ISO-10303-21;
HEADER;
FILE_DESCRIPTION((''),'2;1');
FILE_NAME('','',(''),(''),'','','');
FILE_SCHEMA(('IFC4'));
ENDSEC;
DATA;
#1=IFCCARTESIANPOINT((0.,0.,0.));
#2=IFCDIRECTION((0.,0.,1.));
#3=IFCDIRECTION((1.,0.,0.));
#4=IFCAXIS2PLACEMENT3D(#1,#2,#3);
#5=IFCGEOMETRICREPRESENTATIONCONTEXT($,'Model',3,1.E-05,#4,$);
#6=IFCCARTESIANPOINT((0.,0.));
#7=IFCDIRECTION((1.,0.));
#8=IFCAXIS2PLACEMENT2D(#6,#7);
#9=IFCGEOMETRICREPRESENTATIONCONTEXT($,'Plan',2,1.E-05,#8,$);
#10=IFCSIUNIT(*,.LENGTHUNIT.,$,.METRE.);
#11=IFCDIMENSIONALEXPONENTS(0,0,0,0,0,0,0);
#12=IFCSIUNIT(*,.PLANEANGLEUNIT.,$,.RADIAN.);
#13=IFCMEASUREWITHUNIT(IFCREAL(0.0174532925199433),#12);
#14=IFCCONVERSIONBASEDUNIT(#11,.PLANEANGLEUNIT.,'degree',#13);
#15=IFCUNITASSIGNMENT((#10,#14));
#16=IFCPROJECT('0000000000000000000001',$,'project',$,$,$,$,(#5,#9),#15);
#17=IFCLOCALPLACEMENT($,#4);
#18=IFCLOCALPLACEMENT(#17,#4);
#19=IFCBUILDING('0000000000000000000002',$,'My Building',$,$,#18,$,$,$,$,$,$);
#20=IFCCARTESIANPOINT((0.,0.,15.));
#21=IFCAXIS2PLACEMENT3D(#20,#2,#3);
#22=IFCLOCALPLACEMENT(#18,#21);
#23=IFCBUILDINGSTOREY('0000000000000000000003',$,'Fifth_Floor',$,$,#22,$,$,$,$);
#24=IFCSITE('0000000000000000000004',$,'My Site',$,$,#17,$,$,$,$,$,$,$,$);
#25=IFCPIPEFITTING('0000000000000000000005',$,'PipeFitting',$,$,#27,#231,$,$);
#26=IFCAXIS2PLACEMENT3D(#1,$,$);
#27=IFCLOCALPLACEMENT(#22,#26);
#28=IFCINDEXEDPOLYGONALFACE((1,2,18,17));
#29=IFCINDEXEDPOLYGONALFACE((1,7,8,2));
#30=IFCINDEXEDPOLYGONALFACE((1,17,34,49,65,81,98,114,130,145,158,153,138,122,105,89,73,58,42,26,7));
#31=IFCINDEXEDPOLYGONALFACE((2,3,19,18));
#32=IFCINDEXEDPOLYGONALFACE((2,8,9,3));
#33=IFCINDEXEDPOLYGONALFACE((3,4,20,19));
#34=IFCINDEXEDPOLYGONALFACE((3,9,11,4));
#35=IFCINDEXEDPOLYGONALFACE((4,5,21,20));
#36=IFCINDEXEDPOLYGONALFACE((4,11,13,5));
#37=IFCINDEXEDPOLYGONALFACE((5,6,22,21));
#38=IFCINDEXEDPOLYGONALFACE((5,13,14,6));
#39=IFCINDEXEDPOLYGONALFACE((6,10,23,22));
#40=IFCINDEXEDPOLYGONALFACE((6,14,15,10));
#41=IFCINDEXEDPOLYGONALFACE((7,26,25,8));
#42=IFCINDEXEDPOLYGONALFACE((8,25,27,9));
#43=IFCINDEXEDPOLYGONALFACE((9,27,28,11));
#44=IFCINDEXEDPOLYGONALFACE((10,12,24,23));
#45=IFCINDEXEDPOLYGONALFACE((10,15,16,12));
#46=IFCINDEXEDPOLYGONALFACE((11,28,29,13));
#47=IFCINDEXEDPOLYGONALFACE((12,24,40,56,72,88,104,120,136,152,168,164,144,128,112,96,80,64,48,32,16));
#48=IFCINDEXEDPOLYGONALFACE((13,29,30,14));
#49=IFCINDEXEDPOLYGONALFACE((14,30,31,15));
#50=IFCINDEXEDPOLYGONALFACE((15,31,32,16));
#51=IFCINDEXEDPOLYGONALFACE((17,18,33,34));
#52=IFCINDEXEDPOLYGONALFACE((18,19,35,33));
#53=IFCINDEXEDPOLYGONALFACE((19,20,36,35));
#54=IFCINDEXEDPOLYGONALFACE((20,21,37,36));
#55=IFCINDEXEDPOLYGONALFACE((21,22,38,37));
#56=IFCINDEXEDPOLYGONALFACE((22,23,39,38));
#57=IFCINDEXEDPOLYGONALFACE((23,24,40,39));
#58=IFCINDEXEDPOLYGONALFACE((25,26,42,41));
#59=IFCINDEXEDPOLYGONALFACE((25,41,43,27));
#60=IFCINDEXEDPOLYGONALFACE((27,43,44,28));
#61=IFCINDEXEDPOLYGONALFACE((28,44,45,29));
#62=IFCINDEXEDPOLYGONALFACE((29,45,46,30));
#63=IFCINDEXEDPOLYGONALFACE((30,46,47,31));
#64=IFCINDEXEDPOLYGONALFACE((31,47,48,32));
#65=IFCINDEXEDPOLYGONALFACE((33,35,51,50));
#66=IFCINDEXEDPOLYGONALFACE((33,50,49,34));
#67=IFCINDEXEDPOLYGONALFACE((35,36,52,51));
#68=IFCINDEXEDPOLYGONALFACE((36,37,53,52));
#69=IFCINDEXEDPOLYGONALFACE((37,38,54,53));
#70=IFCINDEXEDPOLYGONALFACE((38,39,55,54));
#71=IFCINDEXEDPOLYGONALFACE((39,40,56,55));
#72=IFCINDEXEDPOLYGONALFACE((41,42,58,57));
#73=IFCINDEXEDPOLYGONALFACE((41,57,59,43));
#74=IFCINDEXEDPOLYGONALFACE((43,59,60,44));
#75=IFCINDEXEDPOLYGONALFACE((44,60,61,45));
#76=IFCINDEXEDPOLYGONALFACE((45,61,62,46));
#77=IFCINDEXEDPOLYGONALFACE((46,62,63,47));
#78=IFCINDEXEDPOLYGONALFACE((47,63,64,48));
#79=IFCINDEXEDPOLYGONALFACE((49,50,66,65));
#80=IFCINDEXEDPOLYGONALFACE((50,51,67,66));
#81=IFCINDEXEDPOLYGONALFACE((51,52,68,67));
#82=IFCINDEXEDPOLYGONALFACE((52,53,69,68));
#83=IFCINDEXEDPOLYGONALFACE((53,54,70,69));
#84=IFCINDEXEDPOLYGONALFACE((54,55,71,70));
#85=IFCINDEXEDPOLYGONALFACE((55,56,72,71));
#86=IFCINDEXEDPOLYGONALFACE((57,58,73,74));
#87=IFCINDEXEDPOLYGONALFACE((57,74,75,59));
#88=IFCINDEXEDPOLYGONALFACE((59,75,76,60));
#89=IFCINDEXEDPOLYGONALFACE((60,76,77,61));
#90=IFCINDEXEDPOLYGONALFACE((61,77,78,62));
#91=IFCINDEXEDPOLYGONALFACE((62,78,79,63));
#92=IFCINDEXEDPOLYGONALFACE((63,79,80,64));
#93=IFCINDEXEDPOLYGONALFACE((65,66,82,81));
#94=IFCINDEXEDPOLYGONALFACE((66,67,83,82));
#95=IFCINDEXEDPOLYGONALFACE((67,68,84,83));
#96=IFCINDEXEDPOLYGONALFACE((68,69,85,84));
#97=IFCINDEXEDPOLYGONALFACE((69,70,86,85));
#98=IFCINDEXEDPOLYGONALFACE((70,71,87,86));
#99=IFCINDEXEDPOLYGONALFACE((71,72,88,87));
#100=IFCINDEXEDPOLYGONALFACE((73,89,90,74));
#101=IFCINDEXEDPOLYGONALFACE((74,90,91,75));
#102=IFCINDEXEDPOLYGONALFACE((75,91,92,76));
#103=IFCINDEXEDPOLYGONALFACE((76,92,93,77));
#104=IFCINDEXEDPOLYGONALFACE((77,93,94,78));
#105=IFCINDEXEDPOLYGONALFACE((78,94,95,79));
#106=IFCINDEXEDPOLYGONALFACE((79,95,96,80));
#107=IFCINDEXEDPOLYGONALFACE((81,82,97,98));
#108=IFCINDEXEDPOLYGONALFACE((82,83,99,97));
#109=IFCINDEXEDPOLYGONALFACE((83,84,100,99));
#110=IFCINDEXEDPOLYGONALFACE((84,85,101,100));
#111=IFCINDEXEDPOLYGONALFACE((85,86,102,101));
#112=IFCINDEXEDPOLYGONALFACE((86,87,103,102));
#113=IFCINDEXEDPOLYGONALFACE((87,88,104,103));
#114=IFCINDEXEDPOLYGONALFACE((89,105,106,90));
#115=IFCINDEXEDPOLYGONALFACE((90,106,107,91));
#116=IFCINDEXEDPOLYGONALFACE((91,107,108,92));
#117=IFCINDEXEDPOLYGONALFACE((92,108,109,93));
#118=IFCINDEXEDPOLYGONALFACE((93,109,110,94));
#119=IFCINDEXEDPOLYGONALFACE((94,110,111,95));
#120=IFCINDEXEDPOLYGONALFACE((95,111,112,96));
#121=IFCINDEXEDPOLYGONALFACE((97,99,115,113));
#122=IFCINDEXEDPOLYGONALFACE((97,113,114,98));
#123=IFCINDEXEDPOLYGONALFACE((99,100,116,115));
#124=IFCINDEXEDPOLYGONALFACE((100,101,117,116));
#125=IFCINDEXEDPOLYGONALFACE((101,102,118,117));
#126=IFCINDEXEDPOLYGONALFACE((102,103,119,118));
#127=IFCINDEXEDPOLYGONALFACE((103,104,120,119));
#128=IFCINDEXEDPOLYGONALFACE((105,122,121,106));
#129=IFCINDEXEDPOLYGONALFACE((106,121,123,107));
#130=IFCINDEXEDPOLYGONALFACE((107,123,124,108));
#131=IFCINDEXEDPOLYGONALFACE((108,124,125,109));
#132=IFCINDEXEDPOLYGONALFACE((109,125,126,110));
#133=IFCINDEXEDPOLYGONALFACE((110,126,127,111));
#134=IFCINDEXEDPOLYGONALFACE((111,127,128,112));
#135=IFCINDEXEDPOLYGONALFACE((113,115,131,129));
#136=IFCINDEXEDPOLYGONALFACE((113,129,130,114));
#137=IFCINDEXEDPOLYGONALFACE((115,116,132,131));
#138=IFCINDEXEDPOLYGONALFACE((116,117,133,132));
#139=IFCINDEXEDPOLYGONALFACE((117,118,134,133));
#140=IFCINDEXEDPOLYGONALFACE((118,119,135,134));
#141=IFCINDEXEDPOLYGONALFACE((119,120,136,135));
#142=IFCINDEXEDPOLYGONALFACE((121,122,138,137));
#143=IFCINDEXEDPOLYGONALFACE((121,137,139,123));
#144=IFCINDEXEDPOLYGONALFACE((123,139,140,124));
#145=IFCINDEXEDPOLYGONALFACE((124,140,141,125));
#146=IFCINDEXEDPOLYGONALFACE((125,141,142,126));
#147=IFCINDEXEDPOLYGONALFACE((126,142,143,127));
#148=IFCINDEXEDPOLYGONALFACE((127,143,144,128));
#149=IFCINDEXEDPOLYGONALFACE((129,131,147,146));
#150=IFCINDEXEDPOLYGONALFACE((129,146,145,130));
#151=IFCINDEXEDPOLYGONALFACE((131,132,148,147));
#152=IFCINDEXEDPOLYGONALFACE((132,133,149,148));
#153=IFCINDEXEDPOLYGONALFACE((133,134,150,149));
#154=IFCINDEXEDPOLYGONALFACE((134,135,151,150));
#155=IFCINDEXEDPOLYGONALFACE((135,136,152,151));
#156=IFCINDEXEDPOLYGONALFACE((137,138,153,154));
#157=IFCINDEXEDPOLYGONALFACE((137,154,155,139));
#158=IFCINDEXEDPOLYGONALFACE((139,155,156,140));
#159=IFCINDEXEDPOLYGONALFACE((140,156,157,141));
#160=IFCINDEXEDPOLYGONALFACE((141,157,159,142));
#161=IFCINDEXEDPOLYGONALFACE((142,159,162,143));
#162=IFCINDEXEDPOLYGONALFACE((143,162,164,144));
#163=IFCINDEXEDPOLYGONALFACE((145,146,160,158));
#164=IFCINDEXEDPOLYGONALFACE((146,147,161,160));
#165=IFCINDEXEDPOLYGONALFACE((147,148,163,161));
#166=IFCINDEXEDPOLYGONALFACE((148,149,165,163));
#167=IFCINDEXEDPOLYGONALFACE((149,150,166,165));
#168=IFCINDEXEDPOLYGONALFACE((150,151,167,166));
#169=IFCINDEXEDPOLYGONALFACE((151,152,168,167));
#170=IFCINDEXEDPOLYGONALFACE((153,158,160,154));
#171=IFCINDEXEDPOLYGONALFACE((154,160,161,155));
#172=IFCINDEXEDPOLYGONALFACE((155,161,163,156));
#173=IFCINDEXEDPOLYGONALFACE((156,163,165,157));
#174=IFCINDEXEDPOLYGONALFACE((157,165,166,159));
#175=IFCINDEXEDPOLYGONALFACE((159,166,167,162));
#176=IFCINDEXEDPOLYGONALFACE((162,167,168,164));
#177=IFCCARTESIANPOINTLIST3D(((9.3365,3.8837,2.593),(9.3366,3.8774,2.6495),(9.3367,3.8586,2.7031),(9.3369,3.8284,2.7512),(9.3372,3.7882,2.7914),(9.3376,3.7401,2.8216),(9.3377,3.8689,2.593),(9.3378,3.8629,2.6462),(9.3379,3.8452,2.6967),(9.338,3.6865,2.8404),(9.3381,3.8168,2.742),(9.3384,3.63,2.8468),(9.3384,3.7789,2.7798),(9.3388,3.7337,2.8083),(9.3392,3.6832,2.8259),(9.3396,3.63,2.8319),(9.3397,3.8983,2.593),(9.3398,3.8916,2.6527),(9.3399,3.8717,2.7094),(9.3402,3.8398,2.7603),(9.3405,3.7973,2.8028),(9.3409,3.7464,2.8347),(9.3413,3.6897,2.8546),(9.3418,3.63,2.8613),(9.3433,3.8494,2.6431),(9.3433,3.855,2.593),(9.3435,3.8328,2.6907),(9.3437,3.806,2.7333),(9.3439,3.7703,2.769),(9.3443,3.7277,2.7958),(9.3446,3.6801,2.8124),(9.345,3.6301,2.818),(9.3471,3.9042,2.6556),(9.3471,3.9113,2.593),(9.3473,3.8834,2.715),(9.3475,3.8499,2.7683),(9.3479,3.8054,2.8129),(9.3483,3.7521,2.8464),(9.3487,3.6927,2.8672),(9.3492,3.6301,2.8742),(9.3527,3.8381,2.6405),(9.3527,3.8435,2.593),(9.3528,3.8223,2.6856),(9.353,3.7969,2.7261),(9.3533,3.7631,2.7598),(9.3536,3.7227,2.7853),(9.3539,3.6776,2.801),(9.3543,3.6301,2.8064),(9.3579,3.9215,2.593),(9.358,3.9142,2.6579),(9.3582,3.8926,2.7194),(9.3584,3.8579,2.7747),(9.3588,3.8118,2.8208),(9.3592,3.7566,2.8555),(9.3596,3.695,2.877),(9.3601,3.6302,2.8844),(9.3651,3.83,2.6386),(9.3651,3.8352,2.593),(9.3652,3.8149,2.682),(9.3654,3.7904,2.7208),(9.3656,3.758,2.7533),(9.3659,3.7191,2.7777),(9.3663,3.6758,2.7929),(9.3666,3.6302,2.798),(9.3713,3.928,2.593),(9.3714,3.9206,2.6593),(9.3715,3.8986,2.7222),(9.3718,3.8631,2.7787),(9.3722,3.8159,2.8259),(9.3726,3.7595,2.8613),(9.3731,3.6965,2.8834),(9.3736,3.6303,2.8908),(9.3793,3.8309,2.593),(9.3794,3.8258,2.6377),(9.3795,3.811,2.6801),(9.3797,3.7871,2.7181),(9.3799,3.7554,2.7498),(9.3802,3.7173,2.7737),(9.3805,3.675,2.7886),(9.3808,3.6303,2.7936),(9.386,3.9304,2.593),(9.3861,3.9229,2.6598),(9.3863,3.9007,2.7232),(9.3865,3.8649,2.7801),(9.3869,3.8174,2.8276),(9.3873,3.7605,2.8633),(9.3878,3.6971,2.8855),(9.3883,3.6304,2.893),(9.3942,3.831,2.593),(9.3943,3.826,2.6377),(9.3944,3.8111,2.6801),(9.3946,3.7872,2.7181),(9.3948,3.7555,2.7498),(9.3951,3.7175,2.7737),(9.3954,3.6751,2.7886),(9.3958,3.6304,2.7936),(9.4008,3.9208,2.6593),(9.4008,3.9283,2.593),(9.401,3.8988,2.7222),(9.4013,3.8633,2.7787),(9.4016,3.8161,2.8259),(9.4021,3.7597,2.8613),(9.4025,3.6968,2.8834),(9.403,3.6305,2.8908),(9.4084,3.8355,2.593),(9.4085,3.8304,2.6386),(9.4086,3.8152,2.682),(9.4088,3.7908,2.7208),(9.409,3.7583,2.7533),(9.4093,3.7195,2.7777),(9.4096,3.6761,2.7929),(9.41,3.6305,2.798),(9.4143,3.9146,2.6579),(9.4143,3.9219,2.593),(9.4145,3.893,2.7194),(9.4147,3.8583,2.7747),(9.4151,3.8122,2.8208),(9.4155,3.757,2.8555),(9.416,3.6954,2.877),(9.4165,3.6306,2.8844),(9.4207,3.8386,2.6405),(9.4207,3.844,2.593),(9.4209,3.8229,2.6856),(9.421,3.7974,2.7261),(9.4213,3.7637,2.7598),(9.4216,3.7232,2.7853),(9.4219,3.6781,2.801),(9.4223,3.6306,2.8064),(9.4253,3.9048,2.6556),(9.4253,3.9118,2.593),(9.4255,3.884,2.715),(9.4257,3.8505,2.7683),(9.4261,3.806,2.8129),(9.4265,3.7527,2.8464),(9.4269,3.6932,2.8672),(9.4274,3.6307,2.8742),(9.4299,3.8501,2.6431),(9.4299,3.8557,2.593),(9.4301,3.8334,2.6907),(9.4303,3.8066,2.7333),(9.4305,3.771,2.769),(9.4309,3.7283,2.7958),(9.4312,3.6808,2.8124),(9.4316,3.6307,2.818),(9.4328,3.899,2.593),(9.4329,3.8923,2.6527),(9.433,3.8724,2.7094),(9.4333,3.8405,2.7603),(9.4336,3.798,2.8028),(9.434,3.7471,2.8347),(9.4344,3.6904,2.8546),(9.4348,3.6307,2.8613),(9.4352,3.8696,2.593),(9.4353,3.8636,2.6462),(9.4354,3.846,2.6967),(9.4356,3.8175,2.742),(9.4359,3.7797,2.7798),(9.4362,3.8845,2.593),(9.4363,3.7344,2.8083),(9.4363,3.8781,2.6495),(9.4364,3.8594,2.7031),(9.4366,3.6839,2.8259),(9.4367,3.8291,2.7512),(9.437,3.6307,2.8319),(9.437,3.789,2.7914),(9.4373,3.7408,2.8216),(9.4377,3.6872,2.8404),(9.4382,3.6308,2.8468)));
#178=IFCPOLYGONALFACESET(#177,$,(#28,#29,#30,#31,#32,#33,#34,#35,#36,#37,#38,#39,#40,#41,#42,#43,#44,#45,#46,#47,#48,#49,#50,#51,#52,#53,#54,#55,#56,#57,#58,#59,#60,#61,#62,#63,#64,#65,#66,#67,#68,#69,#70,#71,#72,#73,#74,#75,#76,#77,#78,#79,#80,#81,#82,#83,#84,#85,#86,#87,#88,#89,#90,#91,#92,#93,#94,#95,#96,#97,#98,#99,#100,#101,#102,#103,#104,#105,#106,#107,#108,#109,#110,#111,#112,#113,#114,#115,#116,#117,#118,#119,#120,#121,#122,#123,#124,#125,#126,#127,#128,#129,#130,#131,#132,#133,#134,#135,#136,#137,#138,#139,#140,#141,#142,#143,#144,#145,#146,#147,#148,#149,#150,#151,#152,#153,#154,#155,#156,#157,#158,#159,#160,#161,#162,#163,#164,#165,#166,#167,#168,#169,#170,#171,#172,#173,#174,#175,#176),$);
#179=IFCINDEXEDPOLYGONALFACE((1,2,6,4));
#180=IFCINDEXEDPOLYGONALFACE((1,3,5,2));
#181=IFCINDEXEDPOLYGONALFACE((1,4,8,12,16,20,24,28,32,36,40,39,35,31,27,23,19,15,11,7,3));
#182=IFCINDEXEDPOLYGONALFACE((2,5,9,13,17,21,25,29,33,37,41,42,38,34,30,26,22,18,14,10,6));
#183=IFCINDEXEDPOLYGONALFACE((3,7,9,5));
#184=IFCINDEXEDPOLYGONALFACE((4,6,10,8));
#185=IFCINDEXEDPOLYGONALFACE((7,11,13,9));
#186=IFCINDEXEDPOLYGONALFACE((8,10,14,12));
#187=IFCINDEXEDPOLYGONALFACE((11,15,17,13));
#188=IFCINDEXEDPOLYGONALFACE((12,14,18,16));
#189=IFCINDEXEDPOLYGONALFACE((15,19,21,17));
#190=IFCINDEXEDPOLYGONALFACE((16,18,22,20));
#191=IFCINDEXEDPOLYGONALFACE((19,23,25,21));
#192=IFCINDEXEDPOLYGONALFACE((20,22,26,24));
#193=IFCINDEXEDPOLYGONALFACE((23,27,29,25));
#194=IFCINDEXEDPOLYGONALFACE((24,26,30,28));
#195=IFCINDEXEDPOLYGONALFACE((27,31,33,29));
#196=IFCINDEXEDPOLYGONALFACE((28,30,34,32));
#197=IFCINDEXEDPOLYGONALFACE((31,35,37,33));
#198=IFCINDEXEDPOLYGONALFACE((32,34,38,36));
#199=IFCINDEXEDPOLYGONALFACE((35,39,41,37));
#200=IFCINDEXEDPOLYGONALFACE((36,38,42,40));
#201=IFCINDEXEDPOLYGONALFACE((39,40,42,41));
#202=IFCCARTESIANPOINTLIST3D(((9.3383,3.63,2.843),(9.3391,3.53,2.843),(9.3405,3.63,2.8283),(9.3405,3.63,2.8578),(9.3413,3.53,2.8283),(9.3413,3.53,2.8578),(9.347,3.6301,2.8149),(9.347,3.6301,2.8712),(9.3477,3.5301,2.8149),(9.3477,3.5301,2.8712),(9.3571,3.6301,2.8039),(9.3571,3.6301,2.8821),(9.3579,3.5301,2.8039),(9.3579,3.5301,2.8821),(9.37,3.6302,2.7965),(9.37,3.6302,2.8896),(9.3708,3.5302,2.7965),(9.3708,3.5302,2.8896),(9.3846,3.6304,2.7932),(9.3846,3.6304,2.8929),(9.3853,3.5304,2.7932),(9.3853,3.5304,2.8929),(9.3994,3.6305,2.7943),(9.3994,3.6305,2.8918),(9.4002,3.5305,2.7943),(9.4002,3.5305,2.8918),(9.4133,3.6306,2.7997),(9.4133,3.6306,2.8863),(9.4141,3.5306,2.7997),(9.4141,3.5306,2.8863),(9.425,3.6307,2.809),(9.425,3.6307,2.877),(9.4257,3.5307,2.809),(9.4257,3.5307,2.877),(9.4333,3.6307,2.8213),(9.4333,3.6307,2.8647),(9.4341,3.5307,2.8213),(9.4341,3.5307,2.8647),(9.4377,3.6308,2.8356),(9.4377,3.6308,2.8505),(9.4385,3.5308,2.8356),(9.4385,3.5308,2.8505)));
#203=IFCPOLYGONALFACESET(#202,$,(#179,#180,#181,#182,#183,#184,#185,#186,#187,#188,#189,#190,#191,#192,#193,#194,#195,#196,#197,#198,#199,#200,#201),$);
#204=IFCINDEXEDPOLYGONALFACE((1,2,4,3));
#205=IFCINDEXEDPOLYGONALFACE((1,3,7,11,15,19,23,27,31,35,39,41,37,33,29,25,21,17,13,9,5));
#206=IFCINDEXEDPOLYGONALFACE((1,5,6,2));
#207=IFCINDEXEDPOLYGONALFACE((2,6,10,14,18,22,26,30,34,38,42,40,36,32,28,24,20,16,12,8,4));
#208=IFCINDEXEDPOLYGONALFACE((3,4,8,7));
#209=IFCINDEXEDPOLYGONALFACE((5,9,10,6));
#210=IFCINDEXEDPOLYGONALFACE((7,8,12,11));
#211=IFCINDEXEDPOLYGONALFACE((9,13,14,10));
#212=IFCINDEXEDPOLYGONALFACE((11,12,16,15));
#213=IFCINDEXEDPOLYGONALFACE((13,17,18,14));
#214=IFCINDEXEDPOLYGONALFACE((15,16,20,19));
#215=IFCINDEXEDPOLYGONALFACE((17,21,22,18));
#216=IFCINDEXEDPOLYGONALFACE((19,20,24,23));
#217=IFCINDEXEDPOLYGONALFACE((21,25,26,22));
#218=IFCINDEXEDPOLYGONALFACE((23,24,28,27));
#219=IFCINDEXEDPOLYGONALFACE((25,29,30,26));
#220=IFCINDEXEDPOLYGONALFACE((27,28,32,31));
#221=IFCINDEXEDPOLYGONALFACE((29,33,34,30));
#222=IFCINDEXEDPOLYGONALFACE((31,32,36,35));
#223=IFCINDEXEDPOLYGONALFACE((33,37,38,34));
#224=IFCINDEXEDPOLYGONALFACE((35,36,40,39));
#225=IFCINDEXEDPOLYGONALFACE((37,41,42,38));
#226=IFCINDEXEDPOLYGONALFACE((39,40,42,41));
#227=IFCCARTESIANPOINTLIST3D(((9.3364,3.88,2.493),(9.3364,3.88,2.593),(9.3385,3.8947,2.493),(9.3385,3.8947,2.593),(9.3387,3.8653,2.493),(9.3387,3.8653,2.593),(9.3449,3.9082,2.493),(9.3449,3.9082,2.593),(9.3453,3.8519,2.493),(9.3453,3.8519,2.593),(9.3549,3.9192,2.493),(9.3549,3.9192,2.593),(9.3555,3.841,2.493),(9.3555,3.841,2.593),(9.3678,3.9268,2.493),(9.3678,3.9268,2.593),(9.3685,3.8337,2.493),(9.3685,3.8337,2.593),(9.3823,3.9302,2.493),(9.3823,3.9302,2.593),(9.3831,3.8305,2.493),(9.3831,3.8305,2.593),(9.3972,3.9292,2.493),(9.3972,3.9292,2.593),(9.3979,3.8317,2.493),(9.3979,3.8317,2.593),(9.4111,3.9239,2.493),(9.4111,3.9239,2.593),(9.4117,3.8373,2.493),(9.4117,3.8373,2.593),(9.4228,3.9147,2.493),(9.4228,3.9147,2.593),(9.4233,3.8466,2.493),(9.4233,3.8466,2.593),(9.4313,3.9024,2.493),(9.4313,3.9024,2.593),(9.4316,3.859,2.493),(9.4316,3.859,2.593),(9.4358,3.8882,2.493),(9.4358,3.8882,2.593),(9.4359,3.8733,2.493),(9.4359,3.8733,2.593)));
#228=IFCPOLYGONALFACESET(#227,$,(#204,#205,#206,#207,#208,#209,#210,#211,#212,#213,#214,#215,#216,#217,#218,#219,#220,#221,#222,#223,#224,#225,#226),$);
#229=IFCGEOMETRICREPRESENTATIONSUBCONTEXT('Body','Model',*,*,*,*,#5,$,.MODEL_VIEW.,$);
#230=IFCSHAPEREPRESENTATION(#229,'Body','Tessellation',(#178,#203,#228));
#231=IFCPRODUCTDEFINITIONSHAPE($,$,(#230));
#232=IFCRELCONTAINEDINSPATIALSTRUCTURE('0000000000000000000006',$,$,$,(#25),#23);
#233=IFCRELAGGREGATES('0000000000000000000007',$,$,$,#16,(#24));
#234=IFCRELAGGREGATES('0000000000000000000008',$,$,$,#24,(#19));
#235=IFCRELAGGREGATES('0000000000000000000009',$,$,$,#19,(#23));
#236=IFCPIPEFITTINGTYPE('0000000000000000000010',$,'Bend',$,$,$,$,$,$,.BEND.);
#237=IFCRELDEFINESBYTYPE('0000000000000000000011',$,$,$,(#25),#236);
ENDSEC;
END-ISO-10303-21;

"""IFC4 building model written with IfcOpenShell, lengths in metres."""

from ifc_helpers import new_model, entity, si_unit, converted_unit, frame, origin_with_axes, origin_2d_with_axis, place, context, subcontext, project, spatial, circle, extrude, source, transform, mapped, type_object, type_shapes, element, save


model = new_model("IFC4")

# Units and contexts
model_context = context("Model", 3, precision=1e-05, world=origin_with_axes())
plan_context = context("Plan", 2, precision=1e-05, world=origin_2d_with_axis())
body_context = subcontext(model_context, "Body", "Model", "MODEL_VIEW")
ifc_project = project(units=[si_unit("LENGTHUNIT", "METRE"), converted_unit("PLANEANGLEUNIT", "degree", entity("IfcReal", 0.0174532925199433), si_unit("PLANEANGLEUNIT", "RADIAN"), dimensions=[0, 0, 0, 0, 0, 0, 0])], contexts=[model_context, plan_context])

# Site, building, storey
site_placement = place(None, origin_with_axes())
site = spatial("IfcSite", under=ifc_project, at=site_placement, Name="My Site")
building_placement = place(site_placement, origin_with_axes())
building = spatial("IfcBuilding", under=site, at=building_placement, Name="My Building")
storey_placement = place(building_placement, frame((0.0, 0.0, 15.0), z_axis=(0.0, 0.0, 1.0), x_axis=(1.0, 0.0, 0.0)))
storey = spatial("IfcBuildingStorey", under=building, at=storey_placement, Name="Fifth_Floor")

# Pipe fitting
pipe_fitting_type = type_object("IfcPipeFittingType", Name="Bend", PredefinedType="BEND")
shared_shape = source(origin_with_axes(), body_context, "Body", "SolidModel", [
    entity("IfcSweptDiskSolid", entity("IfcIndexedPolyCurve", entity("IfcCartesianPointList3D", [[0.0, 0.0, -0.1], [0.0, 0.0732, -0.2768], [0.0, 0.25, -0.35]]), [entity("IfcArcIndex", [1, 2, 3])]), 0.05),
    extrude(circle(Radius=0.05), origin_with_axes(), (0.0, 0.0, -1.0), 0.1),
    extrude(circle(Radius=0.05), frame((0.0, 0.25, -0.35), z_axis=(0.0, 1.0, 0.0), x_axis=(1.0, 0.0, 0.0)), (0.0, 0.0, 1.0), 0.1),
])
type_shapes(pipe_fitting_type, [shared_shape])
for number, where, z_axis, x_axis, name in (
    (1, (9.3891, 3.5304, 2.843), (0.007564, -0.999971, 0.0), (-0.999971, -0.007564, 0.0), "PipeFitting"),
):
    element("IfcPipeFitting", number, at=place(storey_placement, frame(where, z_axis=z_axis, x_axis=x_axis)), inside=storey, type_object=pipe_fitting_type, Name=name, context=body_context, shape_type="MappedRepresentation", body=[
        mapped(shared_shape, transform((0.0, 0.0, 0.0), x_axis=(1.0, 0.0, 0.0), y_axis=(0.0, 1.0, 0.0), z_axis=(0.0, 0.0, 1.0), scale=1.0)),
    ])

save(model, "model.ifc")
